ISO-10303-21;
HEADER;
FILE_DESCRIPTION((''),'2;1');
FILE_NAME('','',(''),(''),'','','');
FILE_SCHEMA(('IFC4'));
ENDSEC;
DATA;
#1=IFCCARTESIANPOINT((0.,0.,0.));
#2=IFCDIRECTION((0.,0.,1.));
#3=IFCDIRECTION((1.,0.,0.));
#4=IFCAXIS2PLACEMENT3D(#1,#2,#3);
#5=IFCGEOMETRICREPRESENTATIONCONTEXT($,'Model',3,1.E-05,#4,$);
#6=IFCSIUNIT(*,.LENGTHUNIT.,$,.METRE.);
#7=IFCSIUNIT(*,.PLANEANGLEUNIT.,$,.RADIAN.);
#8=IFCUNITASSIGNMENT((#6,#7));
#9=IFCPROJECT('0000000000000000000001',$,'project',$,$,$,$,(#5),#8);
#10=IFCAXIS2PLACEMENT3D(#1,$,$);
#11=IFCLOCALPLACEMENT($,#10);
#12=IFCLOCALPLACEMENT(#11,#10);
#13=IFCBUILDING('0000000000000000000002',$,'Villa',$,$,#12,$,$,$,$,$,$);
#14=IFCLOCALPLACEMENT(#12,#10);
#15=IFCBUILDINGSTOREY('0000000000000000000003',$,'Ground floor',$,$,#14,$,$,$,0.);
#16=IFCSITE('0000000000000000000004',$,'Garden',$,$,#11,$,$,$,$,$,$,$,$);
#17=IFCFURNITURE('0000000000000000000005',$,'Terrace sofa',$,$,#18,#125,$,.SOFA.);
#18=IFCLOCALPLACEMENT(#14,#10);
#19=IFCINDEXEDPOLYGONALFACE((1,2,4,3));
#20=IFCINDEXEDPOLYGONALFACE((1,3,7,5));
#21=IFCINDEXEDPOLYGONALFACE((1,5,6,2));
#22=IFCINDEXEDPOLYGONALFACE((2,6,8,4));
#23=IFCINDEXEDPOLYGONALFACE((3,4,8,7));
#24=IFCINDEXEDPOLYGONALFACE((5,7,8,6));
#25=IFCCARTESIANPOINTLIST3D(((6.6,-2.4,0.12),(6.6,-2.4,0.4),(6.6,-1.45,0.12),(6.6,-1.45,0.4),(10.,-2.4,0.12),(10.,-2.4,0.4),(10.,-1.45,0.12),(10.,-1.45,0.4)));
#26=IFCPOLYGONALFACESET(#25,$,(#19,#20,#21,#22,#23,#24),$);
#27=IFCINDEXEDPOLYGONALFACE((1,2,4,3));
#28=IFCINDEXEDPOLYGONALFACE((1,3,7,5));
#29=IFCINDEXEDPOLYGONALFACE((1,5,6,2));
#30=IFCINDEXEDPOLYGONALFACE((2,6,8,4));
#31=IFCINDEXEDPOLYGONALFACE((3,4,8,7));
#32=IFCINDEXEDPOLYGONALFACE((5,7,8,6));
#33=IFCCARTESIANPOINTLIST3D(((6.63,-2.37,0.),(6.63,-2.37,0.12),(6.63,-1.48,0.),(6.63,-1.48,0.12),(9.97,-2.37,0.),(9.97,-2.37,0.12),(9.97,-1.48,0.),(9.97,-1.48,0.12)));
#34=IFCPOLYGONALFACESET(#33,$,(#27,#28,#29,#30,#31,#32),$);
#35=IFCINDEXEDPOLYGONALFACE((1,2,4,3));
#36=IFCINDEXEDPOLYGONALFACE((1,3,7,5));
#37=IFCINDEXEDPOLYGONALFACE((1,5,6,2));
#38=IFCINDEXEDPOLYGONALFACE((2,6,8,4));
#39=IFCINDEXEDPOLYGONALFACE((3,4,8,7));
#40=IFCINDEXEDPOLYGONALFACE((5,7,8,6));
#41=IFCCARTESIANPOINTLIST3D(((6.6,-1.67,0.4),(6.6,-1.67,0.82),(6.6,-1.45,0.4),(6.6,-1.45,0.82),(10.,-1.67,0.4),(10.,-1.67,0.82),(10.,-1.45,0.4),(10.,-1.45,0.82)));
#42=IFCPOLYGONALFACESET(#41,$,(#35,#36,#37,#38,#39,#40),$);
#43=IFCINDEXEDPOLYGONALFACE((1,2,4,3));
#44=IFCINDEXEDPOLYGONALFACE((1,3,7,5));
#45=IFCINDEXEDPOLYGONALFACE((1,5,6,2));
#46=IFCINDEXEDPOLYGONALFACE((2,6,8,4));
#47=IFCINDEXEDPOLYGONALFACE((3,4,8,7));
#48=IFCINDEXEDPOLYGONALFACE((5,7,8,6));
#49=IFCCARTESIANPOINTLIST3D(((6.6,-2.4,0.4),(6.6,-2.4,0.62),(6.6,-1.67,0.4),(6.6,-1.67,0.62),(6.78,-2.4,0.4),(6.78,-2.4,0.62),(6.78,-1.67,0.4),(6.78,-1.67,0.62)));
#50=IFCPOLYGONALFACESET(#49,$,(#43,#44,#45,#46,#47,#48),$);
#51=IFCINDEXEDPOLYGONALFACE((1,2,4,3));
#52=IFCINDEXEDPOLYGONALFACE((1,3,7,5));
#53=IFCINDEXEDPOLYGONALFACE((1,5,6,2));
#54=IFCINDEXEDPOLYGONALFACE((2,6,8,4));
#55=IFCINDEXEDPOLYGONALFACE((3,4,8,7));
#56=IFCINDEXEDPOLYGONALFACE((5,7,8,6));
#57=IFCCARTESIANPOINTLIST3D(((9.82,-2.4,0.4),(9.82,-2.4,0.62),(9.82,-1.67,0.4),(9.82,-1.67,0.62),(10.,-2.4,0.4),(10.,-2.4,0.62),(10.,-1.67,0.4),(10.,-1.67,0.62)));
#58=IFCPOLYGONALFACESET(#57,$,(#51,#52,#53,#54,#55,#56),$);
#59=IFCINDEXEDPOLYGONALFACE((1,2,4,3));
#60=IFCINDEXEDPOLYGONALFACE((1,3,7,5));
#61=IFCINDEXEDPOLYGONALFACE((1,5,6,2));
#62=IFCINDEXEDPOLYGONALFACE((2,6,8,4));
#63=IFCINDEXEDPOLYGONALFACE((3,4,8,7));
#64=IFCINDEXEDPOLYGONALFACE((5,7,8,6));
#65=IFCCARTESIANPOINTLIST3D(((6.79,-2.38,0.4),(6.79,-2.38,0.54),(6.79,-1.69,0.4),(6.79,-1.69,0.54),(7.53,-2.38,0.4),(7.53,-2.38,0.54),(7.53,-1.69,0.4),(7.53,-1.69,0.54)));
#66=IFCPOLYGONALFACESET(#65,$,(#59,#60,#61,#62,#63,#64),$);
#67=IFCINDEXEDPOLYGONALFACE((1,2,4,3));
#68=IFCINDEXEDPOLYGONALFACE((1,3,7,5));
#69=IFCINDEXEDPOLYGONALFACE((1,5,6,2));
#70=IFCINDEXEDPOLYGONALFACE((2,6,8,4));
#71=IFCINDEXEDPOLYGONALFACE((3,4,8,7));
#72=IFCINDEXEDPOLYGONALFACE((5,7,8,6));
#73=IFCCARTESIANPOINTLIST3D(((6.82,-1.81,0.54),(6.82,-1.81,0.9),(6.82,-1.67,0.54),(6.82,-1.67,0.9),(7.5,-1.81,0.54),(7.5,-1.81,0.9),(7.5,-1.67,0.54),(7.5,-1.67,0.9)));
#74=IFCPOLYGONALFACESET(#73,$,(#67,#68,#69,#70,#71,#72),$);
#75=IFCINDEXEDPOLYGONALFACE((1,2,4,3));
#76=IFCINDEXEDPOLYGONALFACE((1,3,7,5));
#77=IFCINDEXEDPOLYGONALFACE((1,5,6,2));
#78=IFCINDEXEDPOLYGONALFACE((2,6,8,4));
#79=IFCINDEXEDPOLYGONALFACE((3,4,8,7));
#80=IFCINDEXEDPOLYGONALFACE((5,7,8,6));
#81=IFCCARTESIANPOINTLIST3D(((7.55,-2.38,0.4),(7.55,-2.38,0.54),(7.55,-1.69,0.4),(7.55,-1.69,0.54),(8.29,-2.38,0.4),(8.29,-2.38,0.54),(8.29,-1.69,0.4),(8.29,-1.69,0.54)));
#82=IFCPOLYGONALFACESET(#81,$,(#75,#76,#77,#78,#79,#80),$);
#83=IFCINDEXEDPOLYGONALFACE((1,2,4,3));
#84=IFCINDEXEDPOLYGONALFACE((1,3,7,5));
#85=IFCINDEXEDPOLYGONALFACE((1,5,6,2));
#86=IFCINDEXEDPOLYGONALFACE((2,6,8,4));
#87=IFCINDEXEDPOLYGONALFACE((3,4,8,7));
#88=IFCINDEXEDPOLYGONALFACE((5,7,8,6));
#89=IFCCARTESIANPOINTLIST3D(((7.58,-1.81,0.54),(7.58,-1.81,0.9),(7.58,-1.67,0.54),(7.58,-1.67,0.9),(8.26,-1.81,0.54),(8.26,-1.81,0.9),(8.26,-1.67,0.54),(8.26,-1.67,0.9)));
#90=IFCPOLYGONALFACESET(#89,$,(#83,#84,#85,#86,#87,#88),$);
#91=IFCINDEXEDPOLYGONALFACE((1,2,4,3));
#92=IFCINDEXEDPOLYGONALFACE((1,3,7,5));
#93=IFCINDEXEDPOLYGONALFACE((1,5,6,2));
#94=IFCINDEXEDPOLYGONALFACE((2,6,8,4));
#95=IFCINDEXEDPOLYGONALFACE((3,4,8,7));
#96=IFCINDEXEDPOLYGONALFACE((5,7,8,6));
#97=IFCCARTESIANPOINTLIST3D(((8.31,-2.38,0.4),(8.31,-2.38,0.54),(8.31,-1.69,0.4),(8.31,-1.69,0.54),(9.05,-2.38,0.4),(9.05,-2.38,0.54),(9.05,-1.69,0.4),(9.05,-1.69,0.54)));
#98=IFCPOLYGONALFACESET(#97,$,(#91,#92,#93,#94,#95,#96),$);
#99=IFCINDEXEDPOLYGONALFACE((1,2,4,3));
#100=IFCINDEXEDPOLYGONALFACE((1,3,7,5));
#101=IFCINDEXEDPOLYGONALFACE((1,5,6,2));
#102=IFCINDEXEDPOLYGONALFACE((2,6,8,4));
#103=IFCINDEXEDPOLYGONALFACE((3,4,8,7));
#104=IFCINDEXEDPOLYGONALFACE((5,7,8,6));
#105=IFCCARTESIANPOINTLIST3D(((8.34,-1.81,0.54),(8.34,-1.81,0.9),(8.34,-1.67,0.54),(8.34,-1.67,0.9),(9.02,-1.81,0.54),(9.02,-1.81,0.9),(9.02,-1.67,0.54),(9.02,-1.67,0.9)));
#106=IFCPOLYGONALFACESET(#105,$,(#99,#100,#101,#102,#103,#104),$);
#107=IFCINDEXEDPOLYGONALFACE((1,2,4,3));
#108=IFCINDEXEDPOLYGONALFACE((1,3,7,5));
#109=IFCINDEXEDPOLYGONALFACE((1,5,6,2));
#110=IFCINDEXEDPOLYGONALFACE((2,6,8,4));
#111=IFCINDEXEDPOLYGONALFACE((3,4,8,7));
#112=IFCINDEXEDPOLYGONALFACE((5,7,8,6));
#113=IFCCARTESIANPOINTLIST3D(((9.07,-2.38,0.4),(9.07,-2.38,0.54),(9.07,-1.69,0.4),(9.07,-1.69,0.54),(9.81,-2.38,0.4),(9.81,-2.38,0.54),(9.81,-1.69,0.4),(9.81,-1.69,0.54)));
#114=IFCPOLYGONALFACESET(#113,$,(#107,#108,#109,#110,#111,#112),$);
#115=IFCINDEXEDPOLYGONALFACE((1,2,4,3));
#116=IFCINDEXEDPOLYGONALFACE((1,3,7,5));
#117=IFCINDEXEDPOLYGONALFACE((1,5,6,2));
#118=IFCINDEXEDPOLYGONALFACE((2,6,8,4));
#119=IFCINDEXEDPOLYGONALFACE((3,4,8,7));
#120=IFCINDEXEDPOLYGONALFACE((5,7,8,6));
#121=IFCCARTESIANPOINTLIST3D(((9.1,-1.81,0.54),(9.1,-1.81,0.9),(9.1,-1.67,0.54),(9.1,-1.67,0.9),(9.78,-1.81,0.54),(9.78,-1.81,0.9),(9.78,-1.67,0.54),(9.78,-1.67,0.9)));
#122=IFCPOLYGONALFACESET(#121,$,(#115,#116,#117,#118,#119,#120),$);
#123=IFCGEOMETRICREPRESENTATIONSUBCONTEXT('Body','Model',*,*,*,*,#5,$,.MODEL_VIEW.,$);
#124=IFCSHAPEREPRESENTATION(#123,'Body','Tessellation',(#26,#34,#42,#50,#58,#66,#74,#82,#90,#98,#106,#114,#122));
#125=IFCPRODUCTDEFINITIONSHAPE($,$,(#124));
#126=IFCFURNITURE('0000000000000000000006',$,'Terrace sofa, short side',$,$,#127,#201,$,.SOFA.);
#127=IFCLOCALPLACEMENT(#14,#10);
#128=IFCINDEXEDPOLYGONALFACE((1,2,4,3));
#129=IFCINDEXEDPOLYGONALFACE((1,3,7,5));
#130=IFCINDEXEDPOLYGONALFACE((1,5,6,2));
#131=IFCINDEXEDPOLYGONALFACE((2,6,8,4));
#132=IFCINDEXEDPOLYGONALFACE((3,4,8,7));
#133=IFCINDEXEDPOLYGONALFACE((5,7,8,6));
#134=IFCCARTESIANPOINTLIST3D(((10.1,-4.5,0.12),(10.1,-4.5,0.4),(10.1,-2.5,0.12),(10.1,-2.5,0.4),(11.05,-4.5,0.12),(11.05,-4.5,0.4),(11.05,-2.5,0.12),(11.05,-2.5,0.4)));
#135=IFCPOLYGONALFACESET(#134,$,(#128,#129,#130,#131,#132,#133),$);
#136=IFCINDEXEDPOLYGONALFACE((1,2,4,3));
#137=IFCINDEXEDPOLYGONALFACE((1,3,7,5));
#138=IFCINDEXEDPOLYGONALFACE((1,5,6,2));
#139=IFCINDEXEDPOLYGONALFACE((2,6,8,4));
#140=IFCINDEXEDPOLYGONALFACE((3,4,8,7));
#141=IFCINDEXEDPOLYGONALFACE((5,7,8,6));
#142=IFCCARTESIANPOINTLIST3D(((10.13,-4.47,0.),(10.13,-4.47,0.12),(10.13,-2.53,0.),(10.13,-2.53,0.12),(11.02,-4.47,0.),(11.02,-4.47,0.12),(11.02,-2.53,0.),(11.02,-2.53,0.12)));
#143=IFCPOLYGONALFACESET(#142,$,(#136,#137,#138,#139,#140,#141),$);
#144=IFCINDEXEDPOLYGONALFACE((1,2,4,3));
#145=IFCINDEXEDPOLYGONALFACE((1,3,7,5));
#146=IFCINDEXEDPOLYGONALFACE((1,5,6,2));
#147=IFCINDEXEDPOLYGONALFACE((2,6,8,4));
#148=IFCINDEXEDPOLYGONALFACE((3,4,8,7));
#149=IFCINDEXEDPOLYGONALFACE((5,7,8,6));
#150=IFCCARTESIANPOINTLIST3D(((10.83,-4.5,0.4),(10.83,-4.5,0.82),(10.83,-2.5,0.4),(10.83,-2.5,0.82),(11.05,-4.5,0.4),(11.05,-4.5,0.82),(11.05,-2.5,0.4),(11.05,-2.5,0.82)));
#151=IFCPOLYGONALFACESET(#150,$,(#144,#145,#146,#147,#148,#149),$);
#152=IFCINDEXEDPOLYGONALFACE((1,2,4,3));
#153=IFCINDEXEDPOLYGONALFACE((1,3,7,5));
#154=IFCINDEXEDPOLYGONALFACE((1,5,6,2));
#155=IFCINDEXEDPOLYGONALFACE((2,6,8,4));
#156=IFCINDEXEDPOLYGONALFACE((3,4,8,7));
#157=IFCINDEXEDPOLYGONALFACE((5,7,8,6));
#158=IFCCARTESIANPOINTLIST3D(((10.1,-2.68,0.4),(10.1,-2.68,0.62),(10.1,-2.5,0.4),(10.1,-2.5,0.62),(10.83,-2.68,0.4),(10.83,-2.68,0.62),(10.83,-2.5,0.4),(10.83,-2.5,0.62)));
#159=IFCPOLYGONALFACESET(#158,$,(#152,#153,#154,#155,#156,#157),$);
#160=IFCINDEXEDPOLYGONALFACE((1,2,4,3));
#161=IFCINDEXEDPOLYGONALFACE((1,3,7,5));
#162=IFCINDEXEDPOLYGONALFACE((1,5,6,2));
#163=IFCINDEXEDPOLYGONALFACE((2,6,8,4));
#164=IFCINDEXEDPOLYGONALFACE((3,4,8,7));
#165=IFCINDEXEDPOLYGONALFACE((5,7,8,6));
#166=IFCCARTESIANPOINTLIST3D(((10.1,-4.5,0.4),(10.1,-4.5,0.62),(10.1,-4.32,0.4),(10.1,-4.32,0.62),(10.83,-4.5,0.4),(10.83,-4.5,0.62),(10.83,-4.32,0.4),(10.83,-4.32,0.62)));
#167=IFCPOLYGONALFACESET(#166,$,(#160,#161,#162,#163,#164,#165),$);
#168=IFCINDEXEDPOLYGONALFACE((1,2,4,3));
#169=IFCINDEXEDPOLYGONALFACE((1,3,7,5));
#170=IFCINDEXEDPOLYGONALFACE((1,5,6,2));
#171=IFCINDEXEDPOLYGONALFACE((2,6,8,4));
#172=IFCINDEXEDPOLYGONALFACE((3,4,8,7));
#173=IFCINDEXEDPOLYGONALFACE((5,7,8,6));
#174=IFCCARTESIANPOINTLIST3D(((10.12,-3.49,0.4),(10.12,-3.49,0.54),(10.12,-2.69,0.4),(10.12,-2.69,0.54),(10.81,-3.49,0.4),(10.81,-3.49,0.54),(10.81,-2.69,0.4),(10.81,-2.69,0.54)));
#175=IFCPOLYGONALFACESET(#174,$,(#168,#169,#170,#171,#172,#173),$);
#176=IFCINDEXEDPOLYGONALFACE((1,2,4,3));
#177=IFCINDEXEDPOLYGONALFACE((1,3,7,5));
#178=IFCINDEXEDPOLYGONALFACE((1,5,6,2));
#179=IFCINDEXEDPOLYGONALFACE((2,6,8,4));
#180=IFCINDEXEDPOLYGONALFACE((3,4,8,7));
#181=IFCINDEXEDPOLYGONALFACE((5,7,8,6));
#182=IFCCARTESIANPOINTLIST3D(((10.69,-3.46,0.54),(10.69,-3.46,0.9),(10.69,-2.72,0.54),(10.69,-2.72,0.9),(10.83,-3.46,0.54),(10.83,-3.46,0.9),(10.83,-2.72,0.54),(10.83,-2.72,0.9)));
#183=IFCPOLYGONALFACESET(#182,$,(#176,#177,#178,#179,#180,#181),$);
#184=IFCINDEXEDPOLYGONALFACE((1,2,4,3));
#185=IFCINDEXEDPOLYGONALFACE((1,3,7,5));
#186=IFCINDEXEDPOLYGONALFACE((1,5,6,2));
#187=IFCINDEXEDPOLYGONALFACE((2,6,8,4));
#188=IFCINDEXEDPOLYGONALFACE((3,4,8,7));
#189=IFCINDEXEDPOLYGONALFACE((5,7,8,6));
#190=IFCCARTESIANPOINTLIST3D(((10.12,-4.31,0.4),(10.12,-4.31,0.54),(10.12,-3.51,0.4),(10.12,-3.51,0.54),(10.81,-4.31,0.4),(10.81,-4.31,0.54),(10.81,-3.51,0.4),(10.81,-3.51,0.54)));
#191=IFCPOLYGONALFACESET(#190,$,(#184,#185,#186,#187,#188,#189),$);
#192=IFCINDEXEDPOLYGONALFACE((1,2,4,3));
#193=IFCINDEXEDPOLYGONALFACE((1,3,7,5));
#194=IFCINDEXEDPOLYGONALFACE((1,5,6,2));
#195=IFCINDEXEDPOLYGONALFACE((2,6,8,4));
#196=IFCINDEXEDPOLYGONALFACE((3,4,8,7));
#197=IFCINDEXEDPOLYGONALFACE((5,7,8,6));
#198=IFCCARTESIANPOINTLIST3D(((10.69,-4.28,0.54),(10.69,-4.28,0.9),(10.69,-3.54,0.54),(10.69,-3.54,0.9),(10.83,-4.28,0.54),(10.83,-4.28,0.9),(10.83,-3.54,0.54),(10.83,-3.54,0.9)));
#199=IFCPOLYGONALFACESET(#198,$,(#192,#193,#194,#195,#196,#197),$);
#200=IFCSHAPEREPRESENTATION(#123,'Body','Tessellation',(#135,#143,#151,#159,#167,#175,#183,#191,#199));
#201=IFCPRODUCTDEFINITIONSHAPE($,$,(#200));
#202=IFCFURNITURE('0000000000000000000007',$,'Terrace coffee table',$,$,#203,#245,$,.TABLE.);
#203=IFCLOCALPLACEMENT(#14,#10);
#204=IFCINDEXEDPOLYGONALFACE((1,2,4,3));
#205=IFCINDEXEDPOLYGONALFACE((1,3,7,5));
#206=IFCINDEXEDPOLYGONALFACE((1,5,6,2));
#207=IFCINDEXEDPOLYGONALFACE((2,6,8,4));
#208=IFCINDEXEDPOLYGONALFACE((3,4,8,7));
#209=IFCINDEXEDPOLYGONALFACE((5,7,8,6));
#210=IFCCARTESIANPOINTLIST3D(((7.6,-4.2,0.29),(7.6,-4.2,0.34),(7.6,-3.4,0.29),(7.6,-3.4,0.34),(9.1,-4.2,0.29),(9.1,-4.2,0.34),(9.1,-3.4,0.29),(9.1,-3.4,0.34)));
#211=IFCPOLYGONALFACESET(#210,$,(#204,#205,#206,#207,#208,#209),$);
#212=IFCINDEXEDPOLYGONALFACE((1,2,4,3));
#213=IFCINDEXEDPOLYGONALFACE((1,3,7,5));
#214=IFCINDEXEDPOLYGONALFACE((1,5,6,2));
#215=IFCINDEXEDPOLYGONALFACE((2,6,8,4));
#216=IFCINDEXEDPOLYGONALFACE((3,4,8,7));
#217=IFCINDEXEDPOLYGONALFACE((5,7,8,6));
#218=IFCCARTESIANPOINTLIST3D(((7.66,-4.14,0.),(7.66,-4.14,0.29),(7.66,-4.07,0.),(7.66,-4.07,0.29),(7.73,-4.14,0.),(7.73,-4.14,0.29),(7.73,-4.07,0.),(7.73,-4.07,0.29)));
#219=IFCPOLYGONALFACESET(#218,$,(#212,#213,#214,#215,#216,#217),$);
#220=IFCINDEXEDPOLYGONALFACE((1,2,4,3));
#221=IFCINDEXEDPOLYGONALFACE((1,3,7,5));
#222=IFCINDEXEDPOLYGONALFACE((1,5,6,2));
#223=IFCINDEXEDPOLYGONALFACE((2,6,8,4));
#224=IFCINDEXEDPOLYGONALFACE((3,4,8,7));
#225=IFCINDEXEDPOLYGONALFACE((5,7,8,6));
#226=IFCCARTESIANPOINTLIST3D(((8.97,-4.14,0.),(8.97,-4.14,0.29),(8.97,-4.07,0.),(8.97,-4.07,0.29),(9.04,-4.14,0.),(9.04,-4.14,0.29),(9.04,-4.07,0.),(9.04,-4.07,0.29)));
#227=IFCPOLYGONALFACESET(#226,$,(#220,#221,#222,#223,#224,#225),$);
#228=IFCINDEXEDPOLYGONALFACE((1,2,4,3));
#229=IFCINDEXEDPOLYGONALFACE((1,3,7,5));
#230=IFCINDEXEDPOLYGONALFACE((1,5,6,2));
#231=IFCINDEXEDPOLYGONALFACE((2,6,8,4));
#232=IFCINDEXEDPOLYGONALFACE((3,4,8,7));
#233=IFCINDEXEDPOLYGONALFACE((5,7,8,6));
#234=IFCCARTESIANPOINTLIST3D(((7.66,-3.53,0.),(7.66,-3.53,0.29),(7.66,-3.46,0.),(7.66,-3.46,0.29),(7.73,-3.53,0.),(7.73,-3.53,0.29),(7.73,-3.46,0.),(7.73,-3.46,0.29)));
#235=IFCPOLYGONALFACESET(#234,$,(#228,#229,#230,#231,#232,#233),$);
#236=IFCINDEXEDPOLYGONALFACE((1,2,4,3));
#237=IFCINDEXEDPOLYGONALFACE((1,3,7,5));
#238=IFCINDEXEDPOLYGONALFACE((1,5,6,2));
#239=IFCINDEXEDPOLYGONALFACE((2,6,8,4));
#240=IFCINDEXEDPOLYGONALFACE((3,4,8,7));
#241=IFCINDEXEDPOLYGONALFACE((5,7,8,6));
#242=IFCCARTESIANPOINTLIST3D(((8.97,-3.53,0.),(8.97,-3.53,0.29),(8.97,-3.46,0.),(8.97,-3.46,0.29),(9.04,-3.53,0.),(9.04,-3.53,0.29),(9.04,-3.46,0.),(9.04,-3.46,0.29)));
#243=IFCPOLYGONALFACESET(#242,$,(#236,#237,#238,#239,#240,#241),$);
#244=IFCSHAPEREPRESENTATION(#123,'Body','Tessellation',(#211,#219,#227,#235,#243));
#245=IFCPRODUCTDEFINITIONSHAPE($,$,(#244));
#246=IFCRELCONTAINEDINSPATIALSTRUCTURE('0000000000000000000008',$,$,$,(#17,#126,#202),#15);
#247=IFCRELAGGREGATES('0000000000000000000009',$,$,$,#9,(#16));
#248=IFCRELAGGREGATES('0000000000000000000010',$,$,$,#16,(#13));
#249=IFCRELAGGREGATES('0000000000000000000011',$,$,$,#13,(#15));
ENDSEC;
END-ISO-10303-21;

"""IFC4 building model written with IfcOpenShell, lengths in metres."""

from ifc_helpers import new_model, si_unit, frame, frame_2d, origin, origin_with_axes, place, context, subcontext, project, spatial, rectangle, extrude, element, save


model = new_model("IFC4")

# Units and contexts
model_context = context("Model", 3, precision=1e-05, world=origin_with_axes())
body_context = subcontext(model_context, "Body", "Model", "MODEL_VIEW")
ifc_project = project(units=[si_unit("LENGTHUNIT", "METRE"), si_unit("PLANEANGLEUNIT", "RADIAN")], contexts=[model_context])

# Site, building, storey
site_placement = place(None, origin())
site = spatial("IfcSite", under=ifc_project, at=site_placement, Name="Garden")
building_placement = place(site_placement, origin())
building = spatial("IfcBuilding", under=site, at=building_placement, Name="Villa")
storey_placement = place(building_placement, origin())
storey = spatial("IfcBuildingStorey", under=building, at=storey_placement, Name="Ground floor", Elevation=0.0)

# Furniture
furniture_1_placement = place(storey_placement, frame((6.6, -2.4, 0.0)))
element("IfcFurniture", 1, at=furniture_1_placement, inside=storey, Name="Terrace sofa", PredefinedType="SOFA", context=body_context, shape_type="SweptSolid", body=[
    extrude(rectangle(XDim=3.4, YDim=0.95, at=frame_2d((1.7, 0.475))), frame((0.0, 0.0, 0.12)), (0.0, 0.0, 1.0), 0.28),
    extrude(rectangle(XDim=3.34, YDim=0.89, at=frame_2d((1.67, 0.445))), frame((0.03, 0.03, 0.0)), (0.0, 0.0, 1.0), 0.12),
    extrude(rectangle(XDim=3.4, YDim=0.22, at=frame_2d((1.7, 0.11))), frame((0.0, 0.73, 0.4)), (0.0, 0.0, 1.0), 0.42),
    extrude(rectangle(XDim=0.18, YDim=0.73, at=frame_2d((0.09, 0.365))), frame((0.0, 0.0, 0.4)), (0.0, 0.0, 1.0), 0.22),
    extrude(rectangle(XDim=0.18, YDim=0.73, at=frame_2d((0.09, 0.365))), frame((3.22, 0.0, 0.4)), (0.0, 0.0, 1.0), 0.22),
    extrude(rectangle(XDim=0.74, YDim=0.69, at=frame_2d((0.37, 0.345))), frame((0.19, 0.02, 0.4)), (0.0, 0.0, 1.0), 0.14),
    extrude(rectangle(XDim=0.68, YDim=0.14, at=frame_2d((0.34, 0.07))), frame((0.22, 0.59, 0.54)), (0.0, 0.0, 1.0), 0.36),
    extrude(rectangle(XDim=0.74, YDim=0.69, at=frame_2d((0.37, 0.345))), frame((0.95, 0.02, 0.4)), (0.0, 0.0, 1.0), 0.14),
    extrude(rectangle(XDim=0.68, YDim=0.14, at=frame_2d((0.34, 0.07))), frame((0.98, 0.59, 0.54)), (0.0, 0.0, 1.0), 0.36),
    extrude(rectangle(XDim=0.74, YDim=0.69, at=frame_2d((0.37, 0.345))), frame((1.71, 0.02, 0.4)), (0.0, 0.0, 1.0), 0.14),
    extrude(rectangle(XDim=0.68, YDim=0.14, at=frame_2d((0.34, 0.07))), frame((1.74, 0.59, 0.54)), (0.0, 0.0, 1.0), 0.36),
    extrude(rectangle(XDim=0.74, YDim=0.69, at=frame_2d((0.37, 0.345))), frame((2.47, 0.02, 0.4)), (0.0, 0.0, 1.0), 0.14),
    extrude(rectangle(XDim=0.68, YDim=0.14, at=frame_2d((0.34, 0.07))), frame((2.5, 0.59, 0.54)), (0.0, 0.0, 1.0), 0.36),
])
furniture_2_placement = place(storey_placement, frame((10.1, -2.5, 0.0), x_axis=(0.0, -1.0, 0.0)))
element("IfcFurniture", 2, at=furniture_2_placement, inside=storey, Name="Terrace sofa, short side", PredefinedType="SOFA", context=body_context, shape_type="SweptSolid", body=[
    extrude(rectangle(XDim=2.0, YDim=0.95, at=frame_2d((1.0, 0.475))), frame((0.0, 0.0, 0.12)), (0.0, 0.0, 1.0), 0.28),
    extrude(rectangle(XDim=1.94, YDim=0.89, at=frame_2d((0.97, 0.445))), frame((0.03, 0.03, 0.0)), (0.0, 0.0, 1.0), 0.12),
    extrude(rectangle(XDim=2.0, YDim=0.22, at=frame_2d((1.0, 0.11))), frame((0.0, 0.73, 0.4)), (0.0, 0.0, 1.0), 0.42),
    extrude(rectangle(XDim=0.18, YDim=0.73, at=frame_2d((0.09, 0.365))), frame((0.0, 0.0, 0.4)), (0.0, 0.0, 1.0), 0.22),
    extrude(rectangle(XDim=0.18, YDim=0.73, at=frame_2d((0.09, 0.365))), frame((1.82, 0.0, 0.4)), (0.0, 0.0, 1.0), 0.22),
    extrude(rectangle(XDim=0.8, YDim=0.69, at=frame_2d((0.4, 0.345))), frame((0.19, 0.02, 0.4)), (0.0, 0.0, 1.0), 0.14),
    extrude(rectangle(XDim=0.74, YDim=0.14, at=frame_2d((0.37, 0.07))), frame((0.22, 0.59, 0.54)), (0.0, 0.0, 1.0), 0.36),
    extrude(rectangle(XDim=0.8, YDim=0.69, at=frame_2d((0.4, 0.345))), frame((1.01, 0.02, 0.4)), (0.0, 0.0, 1.0), 0.14),
    extrude(rectangle(XDim=0.74, YDim=0.14, at=frame_2d((0.37, 0.07))), frame((1.04, 0.59, 0.54)), (0.0, 0.0, 1.0), 0.36),
])
furniture_3_placement = place(storey_placement, frame((7.6, -4.2, 0.0)))
element("IfcFurniture", 3, at=furniture_3_placement, inside=storey, Name="Terrace coffee table", PredefinedType="TABLE", context=body_context, shape_type="SweptSolid", body=[
    extrude(rectangle(XDim=1.5, YDim=0.8, at=frame_2d((0.75, 0.4))), frame((0.0, 0.0, 0.29)), (0.0, 0.0, 1.0), 0.05),
    extrude(rectangle(XDim=0.07, YDim=0.07, at=frame_2d((0.035, 0.035))), frame((0.06, 0.06, 0.0)), (0.0, 0.0, 1.0), 0.29),
    extrude(rectangle(XDim=0.07, YDim=0.07, at=frame_2d((0.035, 0.035))), frame((1.37, 0.06, 0.0)), (0.0, 0.0, 1.0), 0.29),
    extrude(rectangle(XDim=0.07, YDim=0.07, at=frame_2d((0.035, 0.035))), frame((0.06, 0.67, 0.0)), (0.0, 0.0, 1.0), 0.29),
    extrude(rectangle(XDim=0.07, YDim=0.07, at=frame_2d((0.035, 0.035))), frame((1.37, 0.67, 0.0)), (0.0, 0.0, 1.0), 0.29),
])

save(model, "model.ifc")
